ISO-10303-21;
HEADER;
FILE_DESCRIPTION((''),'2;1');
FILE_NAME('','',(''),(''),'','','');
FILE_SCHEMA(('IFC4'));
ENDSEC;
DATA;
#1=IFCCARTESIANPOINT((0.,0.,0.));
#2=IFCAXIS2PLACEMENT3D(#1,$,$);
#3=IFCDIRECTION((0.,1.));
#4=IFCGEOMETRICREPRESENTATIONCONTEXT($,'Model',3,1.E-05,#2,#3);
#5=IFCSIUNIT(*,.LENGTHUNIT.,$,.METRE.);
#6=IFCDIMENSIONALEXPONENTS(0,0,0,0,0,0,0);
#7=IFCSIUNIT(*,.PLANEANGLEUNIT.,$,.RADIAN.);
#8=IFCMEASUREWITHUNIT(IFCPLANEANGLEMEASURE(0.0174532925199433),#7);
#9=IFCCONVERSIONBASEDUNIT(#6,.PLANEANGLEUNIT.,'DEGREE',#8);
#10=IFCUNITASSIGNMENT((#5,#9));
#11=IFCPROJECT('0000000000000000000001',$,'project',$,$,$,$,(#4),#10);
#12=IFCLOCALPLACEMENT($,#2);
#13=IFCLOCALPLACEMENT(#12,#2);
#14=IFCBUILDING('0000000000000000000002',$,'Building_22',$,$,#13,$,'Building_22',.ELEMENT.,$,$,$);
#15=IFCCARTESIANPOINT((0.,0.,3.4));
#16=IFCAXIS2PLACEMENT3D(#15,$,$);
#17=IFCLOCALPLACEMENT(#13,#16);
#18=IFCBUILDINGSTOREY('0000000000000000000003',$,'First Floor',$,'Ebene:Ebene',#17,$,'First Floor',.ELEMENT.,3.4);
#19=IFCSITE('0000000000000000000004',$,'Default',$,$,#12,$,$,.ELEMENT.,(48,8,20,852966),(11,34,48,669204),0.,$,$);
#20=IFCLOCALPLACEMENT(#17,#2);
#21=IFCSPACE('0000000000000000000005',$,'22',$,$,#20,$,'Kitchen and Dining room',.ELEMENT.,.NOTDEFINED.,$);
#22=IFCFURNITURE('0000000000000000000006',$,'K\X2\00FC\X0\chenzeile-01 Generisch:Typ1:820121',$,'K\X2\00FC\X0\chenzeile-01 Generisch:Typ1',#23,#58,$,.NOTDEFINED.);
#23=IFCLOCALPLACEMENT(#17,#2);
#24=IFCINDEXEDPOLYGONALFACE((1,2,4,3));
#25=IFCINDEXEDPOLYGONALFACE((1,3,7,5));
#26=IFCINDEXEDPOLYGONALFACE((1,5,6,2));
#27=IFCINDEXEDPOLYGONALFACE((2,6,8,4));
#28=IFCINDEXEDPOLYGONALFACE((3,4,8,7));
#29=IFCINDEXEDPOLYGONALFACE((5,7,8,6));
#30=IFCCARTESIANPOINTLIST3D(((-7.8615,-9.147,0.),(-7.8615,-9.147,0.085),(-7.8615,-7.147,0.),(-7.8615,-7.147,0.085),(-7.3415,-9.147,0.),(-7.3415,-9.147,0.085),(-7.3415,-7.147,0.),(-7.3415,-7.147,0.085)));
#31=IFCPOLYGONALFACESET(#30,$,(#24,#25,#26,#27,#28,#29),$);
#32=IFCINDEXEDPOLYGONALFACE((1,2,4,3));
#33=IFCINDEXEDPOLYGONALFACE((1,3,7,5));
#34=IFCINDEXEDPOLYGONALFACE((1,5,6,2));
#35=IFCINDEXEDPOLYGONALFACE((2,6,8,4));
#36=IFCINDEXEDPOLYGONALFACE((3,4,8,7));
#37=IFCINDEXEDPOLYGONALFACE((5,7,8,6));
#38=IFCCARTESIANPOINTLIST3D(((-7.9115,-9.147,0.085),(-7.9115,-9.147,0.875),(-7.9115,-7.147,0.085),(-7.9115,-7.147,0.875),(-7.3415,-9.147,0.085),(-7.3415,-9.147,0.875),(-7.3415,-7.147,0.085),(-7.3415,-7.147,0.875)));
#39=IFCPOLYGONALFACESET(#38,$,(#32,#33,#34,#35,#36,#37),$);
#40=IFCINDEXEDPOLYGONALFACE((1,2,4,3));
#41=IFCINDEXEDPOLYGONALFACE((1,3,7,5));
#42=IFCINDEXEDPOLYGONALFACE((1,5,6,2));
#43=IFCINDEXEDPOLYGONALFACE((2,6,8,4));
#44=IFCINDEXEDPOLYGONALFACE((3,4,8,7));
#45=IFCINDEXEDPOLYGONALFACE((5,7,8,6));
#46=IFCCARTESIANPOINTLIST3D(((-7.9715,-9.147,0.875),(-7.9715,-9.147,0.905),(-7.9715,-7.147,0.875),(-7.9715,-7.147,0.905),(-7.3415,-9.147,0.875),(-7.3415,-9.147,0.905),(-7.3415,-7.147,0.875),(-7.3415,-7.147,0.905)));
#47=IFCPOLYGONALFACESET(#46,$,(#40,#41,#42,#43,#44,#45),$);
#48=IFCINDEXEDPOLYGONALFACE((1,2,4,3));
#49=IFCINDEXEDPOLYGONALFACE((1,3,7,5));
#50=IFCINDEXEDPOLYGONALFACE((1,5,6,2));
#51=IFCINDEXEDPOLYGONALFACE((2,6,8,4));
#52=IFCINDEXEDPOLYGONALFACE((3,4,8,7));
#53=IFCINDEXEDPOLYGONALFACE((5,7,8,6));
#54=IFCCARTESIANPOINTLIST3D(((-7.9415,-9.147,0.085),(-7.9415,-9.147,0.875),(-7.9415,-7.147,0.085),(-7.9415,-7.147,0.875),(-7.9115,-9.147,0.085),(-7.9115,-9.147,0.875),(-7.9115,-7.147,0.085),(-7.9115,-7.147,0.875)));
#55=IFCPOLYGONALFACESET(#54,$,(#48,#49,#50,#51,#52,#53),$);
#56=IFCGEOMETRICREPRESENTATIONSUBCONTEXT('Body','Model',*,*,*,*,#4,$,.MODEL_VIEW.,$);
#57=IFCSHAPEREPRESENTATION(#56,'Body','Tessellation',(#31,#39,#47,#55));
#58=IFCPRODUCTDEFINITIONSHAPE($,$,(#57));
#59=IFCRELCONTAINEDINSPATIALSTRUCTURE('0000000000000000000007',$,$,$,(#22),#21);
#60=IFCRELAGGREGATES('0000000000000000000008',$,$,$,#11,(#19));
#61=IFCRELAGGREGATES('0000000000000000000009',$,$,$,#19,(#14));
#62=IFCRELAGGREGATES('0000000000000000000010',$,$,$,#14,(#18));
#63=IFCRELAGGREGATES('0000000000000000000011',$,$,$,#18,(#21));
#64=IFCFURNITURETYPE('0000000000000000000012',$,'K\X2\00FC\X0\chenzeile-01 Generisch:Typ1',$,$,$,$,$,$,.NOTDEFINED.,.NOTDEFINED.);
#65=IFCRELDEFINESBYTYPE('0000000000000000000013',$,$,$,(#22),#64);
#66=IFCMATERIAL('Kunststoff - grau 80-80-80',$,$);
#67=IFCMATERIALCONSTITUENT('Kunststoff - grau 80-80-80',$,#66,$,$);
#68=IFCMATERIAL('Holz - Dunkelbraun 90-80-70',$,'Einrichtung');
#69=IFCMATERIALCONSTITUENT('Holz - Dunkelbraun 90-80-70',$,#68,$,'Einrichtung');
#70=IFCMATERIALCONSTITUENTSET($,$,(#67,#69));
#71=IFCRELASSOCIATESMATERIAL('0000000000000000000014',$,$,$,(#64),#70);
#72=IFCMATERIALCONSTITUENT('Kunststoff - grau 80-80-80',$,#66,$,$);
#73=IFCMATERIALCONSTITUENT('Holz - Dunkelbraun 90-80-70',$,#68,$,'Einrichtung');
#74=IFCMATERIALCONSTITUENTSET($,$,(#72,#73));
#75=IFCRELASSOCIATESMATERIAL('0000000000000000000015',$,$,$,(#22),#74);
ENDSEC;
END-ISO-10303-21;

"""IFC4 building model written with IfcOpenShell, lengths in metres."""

from ifc_helpers import new_model, entity, si_unit, converted_unit, direction, frame, origin, place, context, subcontext, project, spatial, indexed_curve, outline, extrude, source, transform, mapped, material, constituent, constituent_set, type_object, type_shapes, element, save


model = new_model("IFC4")

# Units and contexts
model_context = context("Model", 3, precision=1e-05, world=origin(), true_north=direction((0.0, 1.0)))
body_context = subcontext(model_context, "Body", "Model", "MODEL_VIEW")
ifc_project = project(units=[si_unit("LENGTHUNIT", "METRE"), converted_unit("PLANEANGLEUNIT", "DEGREE", entity("IfcPlaneAngleMeasure", 0.0174532925199433), si_unit("PLANEANGLEUNIT", "RADIAN"), dimensions=[0, 0, 0, 0, 0, 0, 0])], contexts=[model_context])

# Site, building, storey
site_placement = place(None, origin())
site = spatial("IfcSite", under=ifc_project, at=site_placement, Name="Default", CompositionType="ELEMENT", RefLatitude=(48, 8, 20, 852966), RefLongitude=(11, 34, 48, 669204), RefElevation=0.0)
building_placement = place(site_placement, origin())
building = spatial("IfcBuilding", under=site, at=building_placement, Name="Building_22", LongName="Building_22", CompositionType="ELEMENT")
storey_placement = place(building_placement, frame((0.0, 0.0, 3.4)))
storey = spatial("IfcBuildingStorey", under=building, at=storey_placement, Name="First Floor", ObjectType="Ebene:Ebene", LongName="First Floor", CompositionType="ELEMENT", Elevation=3.4)

# Shared definitions
ifc_material_1 = material(Name="Kunststoff - grau 80-80-80")
ifc_material_2 = material(Name="Holz - Dunkelbraun 90-80-70", Category="Einrichtung")

# Shared definitions
space_1_placement = place(storey_placement, origin())
space_1 = spatial("IfcSpace", under=storey, at=space_1_placement, Name="22", LongName="Kitchen and Dining room", CompositionType="ELEMENT", PredefinedType="NOTDEFINED")

# Furniture
ifc_constituent_1 = constituent(ifc_material_1, Name="Kunststoff - grau 80-80-80")
ifc_constituent_2 = constituent(ifc_material_2, Name="Holz - Dunkelbraun 90-80-70", Category="Einrichtung")
ifc_constituent_set_1 = constituent_set(constituents=[ifc_constituent_1, ifc_constituent_2])
ifc_constituent_3 = constituent(ifc_material_1, Name="Kunststoff - grau 80-80-80")
ifc_constituent_4 = constituent(ifc_material_2, Name="Holz - Dunkelbraun 90-80-70", Category="Einrichtung")
ifc_constituent_set_2 = constituent_set(constituents=[ifc_constituent_3, ifc_constituent_4])
furniture_type_1 = type_object("IfcFurnitureType", Name="Küchenzeile-01 Generisch:Typ1", AssemblyPlace="NOTDEFINED", PredefinedType="NOTDEFINED", material=ifc_constituent_set_2)
shared_shape_1 = source(origin(), body_context, "Body", "SweptSolid", [
    extrude(outline(indexed_curve([(-0.26, -1.0), (0.26, -1.0), (0.26, 1.0), (-0.26, 1.0), (-0.26, -1.0)], self_intersect=False)), frame((-0.72, -0.04, 0.0), z_axis=(0.0, 0.0, 1.0), x_axis=(0.0, -1.0, 0.0)), (0.0, 0.0, 1.0), 0.085),
    extrude(outline(indexed_curve([(-0.285, -1.0), (0.285, -1.0), (0.285, 1.0), (-0.285, 1.0), (-0.285, -1.0)], self_intersect=False)), frame((-0.72, -0.015, 0.085), z_axis=(0.0, 0.0, 1.0), x_axis=(0.0, -1.0, 0.0)), (0.0, 0.0, 1.0), 0.79),
    extrude(outline(indexed_curve([(-0.315, -1.0), (0.315, -1.0), (0.315, 1.0), (-0.315, 1.0), (-0.315, -1.0)], self_intersect=False)), frame((-0.72, 0.015, 0.875), z_axis=(0.0, 0.0, 1.0), x_axis=(0.0, -1.0, 0.0)), (0.0, 0.0, 1.0), 0.03),
    extrude(outline(indexed_curve([(-0.015, -1.0), (0.015, -1.0), (0.015, 1.0), (-0.015, 1.0), (-0.015, -1.0)], self_intersect=False)), frame((-0.72, 0.285, 0.085), z_axis=(0.0, 0.0, 1.0), x_axis=(0.0, -1.0, 0.0)), (0.0, 0.0, 1.0), 0.79),
])
type_shapes(furniture_type_1, [shared_shape_1])
furniture_1_placement = place(space_1_placement, frame((-7.6415, -7.427, 0.0), z_axis=(0.0, 0.0, 1.0), x_axis=(0.0, 1.0, 0.0)))
element("IfcFurniture", 1, at=furniture_1_placement, inside=space_1, type_object=furniture_type_1, material=ifc_constituent_set_1, Name="Küchenzeile-01 Generisch:Typ1:820121", ObjectType="Küchenzeile-01 Generisch:Typ1", PredefinedType="NOTDEFINED", context=body_context, shape_type="MappedRepresentation", body=[
    mapped(shared_shape_1, transform((0.0, 0.0, 0.0), scale=1.0)),
])

save(model, "model.ifc")
